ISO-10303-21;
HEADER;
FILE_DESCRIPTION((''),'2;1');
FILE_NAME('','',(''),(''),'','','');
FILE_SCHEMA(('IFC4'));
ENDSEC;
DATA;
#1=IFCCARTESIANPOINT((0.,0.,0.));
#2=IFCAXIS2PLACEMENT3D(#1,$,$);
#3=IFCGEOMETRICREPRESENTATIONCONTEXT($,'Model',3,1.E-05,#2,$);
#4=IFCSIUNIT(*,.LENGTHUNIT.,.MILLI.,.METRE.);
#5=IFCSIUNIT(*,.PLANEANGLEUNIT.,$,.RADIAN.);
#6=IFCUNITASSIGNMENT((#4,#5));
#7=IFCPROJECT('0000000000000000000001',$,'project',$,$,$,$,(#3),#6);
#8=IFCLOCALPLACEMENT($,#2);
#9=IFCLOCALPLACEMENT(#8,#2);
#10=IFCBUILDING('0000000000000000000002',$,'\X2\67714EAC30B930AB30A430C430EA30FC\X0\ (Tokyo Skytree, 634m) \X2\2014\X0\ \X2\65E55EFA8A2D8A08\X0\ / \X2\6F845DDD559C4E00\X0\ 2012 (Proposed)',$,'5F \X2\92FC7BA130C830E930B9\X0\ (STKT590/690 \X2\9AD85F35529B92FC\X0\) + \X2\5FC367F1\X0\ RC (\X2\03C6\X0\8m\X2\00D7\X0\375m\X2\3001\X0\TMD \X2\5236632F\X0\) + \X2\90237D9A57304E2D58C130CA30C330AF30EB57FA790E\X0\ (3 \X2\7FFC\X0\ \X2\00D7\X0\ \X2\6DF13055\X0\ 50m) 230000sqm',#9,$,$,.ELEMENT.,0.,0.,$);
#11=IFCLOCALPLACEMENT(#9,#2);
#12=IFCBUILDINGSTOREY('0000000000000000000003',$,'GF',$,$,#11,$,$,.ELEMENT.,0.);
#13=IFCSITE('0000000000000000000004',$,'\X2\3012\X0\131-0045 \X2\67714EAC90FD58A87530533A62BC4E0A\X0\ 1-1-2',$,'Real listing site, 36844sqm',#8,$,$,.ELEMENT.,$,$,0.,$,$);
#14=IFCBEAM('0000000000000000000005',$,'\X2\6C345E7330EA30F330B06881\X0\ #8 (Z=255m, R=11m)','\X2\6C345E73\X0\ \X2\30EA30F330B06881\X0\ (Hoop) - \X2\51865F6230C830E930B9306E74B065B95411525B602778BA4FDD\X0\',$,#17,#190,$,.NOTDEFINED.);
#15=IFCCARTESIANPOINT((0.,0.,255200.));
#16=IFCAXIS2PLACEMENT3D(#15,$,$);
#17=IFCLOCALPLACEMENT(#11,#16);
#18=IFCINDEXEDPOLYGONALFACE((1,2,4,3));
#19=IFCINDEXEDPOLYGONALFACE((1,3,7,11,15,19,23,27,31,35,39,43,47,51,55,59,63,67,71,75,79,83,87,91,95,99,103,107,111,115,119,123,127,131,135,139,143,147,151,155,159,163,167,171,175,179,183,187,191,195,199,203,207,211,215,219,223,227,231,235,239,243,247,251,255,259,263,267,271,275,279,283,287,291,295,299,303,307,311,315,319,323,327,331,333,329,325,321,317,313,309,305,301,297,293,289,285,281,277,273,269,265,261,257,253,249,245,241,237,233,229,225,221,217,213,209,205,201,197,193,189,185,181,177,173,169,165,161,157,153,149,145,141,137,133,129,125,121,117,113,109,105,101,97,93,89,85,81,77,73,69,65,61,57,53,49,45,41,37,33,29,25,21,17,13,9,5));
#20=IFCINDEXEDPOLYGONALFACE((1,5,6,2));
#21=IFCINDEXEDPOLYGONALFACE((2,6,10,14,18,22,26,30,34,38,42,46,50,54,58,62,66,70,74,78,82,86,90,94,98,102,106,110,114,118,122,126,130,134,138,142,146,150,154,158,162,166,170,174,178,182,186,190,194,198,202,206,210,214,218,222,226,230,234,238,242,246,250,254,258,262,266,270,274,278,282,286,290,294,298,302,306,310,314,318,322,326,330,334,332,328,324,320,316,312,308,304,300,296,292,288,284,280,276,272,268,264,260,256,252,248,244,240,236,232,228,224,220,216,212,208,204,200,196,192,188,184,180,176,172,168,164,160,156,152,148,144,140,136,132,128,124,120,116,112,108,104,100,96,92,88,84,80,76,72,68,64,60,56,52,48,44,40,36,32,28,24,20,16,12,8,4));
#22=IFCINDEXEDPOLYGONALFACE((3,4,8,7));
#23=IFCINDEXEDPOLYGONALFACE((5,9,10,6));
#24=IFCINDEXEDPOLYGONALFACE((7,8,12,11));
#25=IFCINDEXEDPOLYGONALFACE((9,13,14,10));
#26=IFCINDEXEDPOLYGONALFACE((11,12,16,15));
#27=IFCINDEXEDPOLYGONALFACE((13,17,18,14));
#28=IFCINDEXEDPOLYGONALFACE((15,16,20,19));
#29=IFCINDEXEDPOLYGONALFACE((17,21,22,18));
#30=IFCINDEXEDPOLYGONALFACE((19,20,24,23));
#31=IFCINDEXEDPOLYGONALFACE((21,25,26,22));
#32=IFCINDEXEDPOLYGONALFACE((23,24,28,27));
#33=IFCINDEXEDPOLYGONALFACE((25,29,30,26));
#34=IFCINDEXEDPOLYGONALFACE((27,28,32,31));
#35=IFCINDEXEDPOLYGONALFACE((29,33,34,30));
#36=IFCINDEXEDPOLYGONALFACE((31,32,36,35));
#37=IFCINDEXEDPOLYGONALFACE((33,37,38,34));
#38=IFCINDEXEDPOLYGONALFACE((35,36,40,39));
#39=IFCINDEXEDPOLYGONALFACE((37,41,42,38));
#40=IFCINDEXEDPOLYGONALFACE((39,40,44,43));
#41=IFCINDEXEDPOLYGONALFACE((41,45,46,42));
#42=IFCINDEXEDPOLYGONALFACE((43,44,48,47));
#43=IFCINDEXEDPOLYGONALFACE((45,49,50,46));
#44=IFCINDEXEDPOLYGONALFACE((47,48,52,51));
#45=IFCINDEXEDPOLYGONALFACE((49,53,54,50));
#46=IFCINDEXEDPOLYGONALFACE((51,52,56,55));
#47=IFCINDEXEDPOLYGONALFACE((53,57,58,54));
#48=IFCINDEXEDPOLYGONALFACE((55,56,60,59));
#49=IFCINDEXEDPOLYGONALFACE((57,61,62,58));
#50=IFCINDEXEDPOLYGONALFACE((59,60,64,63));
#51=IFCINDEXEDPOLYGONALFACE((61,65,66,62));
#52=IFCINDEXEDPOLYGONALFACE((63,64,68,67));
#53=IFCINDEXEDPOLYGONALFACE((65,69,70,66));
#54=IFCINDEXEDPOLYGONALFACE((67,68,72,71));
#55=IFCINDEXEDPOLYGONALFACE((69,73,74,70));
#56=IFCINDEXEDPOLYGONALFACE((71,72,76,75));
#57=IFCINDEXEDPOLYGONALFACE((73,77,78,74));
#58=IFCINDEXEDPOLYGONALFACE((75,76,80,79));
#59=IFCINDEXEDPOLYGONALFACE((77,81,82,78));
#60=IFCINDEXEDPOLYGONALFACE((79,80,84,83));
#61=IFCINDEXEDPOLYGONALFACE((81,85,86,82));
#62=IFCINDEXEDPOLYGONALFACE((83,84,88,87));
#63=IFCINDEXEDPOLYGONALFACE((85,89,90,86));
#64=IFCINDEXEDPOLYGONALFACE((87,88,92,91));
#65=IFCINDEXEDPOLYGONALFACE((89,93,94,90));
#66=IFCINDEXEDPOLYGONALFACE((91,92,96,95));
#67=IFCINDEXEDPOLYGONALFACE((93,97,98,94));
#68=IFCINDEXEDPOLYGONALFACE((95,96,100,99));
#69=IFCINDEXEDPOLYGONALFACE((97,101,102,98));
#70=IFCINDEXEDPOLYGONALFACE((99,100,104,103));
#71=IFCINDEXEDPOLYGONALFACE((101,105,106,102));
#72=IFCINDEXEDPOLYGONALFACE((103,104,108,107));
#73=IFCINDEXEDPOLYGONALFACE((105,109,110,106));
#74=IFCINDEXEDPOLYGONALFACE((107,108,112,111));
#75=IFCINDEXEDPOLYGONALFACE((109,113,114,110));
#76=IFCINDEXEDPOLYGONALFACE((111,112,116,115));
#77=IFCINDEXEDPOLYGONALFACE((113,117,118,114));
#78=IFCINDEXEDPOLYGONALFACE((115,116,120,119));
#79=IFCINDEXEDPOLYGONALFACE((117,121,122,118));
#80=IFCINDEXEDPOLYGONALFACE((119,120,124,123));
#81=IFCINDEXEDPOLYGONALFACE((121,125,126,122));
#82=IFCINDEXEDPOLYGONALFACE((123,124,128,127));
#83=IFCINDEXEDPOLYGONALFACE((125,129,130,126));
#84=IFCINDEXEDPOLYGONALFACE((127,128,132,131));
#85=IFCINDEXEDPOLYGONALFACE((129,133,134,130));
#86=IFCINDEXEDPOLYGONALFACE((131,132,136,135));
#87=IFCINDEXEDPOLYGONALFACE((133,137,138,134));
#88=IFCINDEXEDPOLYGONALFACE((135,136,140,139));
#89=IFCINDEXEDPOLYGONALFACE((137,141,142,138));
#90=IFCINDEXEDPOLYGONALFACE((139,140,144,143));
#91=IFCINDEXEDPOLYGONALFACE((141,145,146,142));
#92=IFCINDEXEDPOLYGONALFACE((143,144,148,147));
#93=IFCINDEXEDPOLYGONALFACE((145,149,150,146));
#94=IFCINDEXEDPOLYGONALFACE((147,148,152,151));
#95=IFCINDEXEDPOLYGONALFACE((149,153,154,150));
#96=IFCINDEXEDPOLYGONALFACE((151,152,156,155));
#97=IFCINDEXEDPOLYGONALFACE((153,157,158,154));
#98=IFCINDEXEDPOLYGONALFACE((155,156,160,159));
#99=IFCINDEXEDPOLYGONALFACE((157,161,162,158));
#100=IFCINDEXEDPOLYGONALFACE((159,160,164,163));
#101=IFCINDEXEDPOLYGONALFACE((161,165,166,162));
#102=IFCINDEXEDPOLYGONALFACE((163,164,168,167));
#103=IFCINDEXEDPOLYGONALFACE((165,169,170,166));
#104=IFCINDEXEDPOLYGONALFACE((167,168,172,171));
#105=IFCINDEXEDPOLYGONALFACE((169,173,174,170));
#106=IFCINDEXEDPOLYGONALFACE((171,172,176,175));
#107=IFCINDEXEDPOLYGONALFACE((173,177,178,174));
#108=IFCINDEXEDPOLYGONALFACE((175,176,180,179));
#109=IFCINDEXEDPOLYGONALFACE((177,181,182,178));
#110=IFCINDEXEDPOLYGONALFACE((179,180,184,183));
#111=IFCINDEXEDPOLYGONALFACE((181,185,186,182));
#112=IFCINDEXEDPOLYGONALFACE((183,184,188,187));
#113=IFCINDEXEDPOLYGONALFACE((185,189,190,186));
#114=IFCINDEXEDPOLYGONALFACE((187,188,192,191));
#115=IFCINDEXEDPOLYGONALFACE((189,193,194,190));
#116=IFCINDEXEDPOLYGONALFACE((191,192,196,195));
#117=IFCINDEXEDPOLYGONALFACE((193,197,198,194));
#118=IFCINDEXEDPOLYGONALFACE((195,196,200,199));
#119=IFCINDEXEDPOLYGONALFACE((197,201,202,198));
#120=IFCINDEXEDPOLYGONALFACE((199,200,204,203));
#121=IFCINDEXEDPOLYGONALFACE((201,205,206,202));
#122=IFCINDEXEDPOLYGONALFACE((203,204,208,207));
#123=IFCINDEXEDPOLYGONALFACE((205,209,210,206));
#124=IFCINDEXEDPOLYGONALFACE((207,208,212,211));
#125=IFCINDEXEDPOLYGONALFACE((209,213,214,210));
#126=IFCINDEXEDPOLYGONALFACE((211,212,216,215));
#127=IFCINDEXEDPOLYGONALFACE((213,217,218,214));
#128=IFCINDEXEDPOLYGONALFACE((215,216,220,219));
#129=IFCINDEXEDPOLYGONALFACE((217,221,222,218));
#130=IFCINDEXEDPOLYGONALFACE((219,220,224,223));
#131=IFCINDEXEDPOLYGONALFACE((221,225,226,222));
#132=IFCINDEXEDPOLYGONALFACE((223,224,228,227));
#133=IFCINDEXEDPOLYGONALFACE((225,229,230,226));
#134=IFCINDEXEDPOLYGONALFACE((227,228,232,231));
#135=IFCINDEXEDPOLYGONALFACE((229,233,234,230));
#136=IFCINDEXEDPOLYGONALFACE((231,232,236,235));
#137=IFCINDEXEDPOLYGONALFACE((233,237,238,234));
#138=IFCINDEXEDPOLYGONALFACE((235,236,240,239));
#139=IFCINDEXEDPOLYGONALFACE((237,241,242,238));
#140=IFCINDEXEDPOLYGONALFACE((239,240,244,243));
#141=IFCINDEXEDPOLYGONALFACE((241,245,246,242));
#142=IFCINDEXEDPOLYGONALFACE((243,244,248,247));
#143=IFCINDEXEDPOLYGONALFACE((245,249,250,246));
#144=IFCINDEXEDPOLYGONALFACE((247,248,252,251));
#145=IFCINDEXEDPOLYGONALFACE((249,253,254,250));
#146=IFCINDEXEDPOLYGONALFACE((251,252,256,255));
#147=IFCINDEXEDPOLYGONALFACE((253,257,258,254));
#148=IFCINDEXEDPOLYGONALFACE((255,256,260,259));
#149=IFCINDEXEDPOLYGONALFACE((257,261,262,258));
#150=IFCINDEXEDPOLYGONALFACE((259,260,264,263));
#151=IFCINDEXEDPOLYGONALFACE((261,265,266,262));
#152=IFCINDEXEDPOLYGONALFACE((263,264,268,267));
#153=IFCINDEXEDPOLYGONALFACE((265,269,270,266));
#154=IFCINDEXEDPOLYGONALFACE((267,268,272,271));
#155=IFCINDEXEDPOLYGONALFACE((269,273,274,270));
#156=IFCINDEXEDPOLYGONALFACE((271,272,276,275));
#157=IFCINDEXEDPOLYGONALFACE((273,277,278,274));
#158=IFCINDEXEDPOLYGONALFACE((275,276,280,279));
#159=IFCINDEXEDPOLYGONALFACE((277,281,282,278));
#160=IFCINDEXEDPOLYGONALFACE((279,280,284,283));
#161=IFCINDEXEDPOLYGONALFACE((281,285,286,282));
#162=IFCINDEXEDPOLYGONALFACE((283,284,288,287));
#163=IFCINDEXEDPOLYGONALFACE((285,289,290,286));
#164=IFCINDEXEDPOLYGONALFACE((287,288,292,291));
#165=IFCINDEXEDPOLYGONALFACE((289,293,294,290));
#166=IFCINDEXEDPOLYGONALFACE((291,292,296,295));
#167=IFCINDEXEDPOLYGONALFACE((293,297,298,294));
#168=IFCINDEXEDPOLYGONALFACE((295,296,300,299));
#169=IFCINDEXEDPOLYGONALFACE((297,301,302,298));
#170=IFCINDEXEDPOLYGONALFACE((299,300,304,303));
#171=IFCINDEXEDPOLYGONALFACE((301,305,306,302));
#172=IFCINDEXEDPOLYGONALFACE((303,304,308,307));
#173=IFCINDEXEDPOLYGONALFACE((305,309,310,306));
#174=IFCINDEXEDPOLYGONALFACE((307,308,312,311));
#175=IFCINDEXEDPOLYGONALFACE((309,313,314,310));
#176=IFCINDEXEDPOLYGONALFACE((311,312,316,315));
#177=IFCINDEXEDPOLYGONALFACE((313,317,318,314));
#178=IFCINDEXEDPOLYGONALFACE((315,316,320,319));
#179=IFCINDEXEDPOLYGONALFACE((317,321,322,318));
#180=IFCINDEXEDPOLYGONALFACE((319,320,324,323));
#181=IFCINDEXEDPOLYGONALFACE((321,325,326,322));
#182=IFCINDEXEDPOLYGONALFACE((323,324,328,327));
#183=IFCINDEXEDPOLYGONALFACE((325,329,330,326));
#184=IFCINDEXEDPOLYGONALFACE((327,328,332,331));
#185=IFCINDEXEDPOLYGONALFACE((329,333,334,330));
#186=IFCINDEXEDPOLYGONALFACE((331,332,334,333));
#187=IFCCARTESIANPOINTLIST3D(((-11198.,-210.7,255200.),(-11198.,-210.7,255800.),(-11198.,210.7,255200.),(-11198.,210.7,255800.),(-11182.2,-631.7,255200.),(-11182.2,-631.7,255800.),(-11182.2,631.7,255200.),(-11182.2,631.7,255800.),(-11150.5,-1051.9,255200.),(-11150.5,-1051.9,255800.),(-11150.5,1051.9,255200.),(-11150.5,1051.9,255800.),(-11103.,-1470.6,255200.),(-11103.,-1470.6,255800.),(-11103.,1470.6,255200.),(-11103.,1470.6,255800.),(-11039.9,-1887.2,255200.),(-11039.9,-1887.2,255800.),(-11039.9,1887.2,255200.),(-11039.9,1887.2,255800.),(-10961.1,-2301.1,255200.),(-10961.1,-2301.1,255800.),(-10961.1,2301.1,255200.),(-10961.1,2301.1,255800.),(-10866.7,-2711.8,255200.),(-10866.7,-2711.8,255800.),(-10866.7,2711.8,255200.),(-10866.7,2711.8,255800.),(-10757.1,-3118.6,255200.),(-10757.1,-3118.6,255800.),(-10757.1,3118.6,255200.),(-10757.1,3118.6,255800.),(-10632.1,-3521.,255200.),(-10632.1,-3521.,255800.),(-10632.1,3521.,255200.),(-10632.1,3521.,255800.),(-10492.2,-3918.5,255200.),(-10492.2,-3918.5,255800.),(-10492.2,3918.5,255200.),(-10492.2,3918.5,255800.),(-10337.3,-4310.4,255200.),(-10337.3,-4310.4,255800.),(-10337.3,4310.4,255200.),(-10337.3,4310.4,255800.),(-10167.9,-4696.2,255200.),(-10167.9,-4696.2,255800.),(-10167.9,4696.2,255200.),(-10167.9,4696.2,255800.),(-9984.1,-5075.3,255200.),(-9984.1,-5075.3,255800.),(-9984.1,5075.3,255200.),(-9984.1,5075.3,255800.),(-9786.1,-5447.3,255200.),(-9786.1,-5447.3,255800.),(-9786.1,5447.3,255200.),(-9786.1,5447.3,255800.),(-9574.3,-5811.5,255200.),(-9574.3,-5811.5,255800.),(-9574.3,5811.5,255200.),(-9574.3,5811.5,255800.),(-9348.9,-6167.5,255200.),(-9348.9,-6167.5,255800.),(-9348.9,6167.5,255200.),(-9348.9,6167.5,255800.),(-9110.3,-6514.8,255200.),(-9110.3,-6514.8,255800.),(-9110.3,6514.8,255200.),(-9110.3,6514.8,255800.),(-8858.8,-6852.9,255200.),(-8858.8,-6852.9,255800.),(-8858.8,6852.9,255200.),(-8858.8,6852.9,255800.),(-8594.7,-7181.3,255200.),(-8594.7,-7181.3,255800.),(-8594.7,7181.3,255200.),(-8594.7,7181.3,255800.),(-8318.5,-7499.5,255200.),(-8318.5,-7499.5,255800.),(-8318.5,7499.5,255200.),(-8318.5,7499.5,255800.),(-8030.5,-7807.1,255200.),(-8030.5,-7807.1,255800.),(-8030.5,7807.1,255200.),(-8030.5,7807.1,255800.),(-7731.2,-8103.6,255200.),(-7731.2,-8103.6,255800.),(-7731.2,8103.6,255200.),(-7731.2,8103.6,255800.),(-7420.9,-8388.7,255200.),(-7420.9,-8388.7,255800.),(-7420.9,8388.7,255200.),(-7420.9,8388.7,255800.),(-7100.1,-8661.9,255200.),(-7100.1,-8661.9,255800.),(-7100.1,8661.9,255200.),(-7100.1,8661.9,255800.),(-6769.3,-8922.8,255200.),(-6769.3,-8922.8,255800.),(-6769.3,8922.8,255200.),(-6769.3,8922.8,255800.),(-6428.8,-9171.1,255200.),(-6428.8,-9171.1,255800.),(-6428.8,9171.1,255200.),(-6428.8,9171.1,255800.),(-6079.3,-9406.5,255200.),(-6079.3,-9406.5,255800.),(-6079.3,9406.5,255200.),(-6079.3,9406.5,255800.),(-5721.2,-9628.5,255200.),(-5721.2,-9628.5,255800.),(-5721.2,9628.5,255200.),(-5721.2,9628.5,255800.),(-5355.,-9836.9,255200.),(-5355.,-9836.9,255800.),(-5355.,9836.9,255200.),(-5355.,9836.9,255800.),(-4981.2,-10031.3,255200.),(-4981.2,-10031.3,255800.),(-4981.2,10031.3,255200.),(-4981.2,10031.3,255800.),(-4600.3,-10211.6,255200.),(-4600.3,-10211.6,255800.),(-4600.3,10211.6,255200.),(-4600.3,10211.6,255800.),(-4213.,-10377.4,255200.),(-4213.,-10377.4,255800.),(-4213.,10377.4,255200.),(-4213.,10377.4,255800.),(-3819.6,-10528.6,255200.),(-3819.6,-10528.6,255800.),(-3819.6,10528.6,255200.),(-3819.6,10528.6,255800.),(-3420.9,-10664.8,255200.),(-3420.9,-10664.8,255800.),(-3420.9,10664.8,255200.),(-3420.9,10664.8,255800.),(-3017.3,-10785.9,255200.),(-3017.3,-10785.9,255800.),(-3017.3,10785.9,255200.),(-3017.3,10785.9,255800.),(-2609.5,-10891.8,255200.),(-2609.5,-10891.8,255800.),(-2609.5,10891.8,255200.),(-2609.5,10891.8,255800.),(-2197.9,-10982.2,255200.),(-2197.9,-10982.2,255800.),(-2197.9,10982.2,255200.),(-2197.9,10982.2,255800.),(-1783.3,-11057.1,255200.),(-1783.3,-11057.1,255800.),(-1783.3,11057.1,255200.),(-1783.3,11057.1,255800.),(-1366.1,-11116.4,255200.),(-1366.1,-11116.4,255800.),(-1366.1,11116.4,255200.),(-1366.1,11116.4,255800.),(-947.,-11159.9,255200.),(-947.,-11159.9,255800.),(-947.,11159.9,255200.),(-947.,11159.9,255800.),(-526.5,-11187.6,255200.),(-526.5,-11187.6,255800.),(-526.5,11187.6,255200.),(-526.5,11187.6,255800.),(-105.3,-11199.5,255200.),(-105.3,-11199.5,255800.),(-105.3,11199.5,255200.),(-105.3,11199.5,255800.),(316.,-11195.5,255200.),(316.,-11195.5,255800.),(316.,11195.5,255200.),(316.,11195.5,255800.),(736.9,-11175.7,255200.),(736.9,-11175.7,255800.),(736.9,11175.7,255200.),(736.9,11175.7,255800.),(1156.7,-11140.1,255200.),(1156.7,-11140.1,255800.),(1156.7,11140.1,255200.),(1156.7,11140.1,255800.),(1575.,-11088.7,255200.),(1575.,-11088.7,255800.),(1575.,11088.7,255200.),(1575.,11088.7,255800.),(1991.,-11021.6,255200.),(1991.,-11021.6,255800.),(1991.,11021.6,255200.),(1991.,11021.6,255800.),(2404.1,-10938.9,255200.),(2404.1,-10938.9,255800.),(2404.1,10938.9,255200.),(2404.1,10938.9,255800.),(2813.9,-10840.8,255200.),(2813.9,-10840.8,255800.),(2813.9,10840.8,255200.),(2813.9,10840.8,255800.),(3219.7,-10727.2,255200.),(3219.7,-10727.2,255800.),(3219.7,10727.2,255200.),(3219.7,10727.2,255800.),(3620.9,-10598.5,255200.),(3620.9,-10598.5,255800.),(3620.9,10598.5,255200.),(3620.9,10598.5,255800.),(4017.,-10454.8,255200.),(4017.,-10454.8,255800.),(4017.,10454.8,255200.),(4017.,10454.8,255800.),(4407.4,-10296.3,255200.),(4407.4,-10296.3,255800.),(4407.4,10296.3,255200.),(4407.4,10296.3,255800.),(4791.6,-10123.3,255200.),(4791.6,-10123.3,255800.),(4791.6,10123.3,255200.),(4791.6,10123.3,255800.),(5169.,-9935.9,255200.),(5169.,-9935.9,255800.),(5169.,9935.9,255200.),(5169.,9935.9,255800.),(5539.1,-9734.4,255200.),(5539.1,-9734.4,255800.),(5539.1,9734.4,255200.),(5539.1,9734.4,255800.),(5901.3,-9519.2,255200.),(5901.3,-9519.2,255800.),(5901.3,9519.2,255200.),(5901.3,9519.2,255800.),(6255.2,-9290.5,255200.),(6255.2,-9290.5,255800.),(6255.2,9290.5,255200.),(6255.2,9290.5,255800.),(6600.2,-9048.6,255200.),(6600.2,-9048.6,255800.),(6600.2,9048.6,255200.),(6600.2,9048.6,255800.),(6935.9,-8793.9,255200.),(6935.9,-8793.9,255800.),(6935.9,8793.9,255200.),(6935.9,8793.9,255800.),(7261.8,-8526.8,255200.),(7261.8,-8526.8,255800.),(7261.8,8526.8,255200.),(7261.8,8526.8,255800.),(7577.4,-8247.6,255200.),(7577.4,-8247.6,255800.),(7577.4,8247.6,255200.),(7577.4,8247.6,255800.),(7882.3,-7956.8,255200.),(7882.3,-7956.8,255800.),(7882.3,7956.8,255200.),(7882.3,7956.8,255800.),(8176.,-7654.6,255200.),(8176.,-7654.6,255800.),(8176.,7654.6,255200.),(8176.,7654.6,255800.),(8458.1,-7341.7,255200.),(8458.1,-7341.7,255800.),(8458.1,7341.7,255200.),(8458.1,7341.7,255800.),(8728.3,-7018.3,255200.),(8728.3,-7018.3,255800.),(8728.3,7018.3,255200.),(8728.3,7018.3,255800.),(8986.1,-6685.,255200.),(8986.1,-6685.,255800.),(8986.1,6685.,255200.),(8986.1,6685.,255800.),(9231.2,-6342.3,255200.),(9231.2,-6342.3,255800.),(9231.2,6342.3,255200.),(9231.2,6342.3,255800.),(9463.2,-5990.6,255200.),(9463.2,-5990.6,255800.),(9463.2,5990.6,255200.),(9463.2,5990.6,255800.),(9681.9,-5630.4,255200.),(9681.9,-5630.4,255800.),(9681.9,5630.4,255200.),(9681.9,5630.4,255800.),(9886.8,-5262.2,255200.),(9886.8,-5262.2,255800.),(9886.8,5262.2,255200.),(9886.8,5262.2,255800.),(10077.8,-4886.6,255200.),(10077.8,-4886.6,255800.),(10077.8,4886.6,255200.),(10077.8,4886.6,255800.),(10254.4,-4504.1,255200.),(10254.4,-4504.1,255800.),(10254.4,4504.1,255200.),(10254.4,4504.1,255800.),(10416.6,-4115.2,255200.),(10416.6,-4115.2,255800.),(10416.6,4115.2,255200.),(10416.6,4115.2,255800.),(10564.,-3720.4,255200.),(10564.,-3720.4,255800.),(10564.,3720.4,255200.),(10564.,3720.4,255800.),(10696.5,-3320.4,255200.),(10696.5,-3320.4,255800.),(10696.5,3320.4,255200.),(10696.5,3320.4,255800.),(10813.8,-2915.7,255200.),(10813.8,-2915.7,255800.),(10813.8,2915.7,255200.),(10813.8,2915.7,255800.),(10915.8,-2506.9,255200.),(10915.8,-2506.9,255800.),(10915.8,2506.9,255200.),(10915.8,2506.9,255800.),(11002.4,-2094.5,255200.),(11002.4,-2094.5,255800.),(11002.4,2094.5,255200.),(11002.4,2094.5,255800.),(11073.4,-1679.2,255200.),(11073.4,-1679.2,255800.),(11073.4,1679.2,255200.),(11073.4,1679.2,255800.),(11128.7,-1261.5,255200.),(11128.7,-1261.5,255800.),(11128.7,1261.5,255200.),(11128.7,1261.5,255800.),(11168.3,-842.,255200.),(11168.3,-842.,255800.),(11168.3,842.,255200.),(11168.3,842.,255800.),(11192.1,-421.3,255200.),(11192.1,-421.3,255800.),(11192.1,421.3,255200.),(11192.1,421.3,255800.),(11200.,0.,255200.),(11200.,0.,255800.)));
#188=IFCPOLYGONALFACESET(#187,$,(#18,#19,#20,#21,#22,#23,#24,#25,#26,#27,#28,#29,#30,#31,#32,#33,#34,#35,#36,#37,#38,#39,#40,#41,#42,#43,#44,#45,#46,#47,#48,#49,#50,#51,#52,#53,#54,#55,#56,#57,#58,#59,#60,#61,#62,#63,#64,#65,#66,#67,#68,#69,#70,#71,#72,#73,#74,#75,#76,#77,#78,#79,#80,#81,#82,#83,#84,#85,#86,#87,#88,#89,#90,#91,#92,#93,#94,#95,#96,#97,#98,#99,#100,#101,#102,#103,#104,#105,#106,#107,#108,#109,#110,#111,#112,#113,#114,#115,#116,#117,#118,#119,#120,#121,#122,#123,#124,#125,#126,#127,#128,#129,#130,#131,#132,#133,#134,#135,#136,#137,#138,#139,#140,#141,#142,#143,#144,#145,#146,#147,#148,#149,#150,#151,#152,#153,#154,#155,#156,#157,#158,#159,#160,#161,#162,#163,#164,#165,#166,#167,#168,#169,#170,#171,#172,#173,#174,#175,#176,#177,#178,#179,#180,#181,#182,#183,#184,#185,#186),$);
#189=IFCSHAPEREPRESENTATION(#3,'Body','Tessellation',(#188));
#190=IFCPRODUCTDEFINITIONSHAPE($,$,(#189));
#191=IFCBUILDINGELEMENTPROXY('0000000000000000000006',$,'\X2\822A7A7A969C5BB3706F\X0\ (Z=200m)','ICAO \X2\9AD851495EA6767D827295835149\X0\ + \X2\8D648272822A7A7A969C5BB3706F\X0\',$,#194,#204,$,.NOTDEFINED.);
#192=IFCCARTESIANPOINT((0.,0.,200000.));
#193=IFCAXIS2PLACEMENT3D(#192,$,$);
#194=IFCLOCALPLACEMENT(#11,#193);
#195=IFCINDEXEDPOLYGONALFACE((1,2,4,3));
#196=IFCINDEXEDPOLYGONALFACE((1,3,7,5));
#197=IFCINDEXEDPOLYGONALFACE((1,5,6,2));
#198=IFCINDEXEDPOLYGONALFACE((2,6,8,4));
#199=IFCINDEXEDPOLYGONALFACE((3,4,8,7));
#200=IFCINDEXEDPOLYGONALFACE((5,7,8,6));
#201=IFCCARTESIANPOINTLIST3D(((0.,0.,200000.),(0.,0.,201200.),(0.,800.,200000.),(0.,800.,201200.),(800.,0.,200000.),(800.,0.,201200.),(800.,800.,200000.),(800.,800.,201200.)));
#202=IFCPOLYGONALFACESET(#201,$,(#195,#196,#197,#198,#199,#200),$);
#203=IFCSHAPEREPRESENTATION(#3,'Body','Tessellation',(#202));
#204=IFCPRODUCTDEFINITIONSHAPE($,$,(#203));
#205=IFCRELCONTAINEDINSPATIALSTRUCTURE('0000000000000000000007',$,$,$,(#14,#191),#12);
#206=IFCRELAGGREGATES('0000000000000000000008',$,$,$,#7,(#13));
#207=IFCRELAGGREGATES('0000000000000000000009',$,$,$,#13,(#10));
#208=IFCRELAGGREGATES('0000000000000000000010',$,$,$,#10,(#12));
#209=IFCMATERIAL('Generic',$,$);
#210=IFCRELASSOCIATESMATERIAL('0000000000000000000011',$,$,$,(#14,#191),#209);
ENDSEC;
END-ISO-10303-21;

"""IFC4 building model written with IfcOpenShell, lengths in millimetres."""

from ifc_helpers import new_model, si_unit, frame, frame_2d, origin, origin_2d, place, context, project, spatial, rectangle, circle, extrude, material, element, save


model = new_model("IFC4")

# Units and contexts
model_context = context("Model", 3, precision=1e-05, world=origin())
ifc_project = project(units=[si_unit("LENGTHUNIT", "METRE", prefix="MILLI"), si_unit("PLANEANGLEUNIT", "RADIAN")], contexts=[model_context])

# Site, building, storey
site_placement = place(None, origin())
site = spatial("IfcSite", under=ifc_project, at=site_placement, Name="〒131-0045 東京都墨田区押上 1-1-2", ObjectType="Real listing site, 36844sqm", CompositionType="ELEMENT", RefElevation=0.0)
building_placement = place(site_placement, origin())
building = spatial("IfcBuilding", under=site, at=building_placement, Name="東京スカイツリー (Tokyo Skytree, 634m) — 日建設計 / 澄川喜一 2012 (Proposed)", ObjectType="5F 鋼管トラス (STKT590/690 高張力鋼) + 心柱 RC (φ8m×375m、TMD 制振) + 連続地中壁ナックル基礎 (3 翼 × 深さ 50m) 230000sqm", CompositionType="ELEMENT", ElevationOfRefHeight=0.0, ElevationOfTerrain=0.0)
storey_placement = place(building_placement, origin())
storey = spatial("IfcBuildingStorey", under=building, at=storey_placement, Name="GF", CompositionType="ELEMENT", Elevation=0.0)

# Shared definitions
ifc_material_1 = material(Name="Generic")

# Beam
beam_1_placement = place(storey_placement, frame((0.0, 0.0, 255200.0)))
element("IfcBeam", 1, at=beam_1_placement, inside=storey, material=ifc_material_1, Name="水平リング梁 #8 (Z=255m, R=11m)", Description="水平 リング梁 (Hoop) - 円形トラスの環方向剛性確保", PredefinedType="NOTDEFINED", context=model_context, shape_type="SweptSolid", body=[
    extrude(circle(Radius=11200.0, at=origin_2d()), frame((0.0, 0.0, 255200.0)), (0.0, 0.0, 1.0), 600.0),
])

# Building element proxy
proxy_placement = place(storey_placement, frame((0.0, 0.0, 200000.0)))
element("IfcBuildingElementProxy", 2, at=proxy_placement, inside=storey, material=ifc_material_1, Name="航空障害灯 (Z=200m)", Description="ICAO 高光度白色閃光 + 赤色航空障害灯", PredefinedType="NOTDEFINED", context=model_context, shape_type="SweptSolid", body=[
    extrude(rectangle(XDim=800.0, YDim=800.0, at=frame_2d((400.0, 400.0))), frame((0.0, 0.0, 200000.0)), (0.0, 0.0, 1.0), 1200.0),
])

save(model, "model.ifc")
